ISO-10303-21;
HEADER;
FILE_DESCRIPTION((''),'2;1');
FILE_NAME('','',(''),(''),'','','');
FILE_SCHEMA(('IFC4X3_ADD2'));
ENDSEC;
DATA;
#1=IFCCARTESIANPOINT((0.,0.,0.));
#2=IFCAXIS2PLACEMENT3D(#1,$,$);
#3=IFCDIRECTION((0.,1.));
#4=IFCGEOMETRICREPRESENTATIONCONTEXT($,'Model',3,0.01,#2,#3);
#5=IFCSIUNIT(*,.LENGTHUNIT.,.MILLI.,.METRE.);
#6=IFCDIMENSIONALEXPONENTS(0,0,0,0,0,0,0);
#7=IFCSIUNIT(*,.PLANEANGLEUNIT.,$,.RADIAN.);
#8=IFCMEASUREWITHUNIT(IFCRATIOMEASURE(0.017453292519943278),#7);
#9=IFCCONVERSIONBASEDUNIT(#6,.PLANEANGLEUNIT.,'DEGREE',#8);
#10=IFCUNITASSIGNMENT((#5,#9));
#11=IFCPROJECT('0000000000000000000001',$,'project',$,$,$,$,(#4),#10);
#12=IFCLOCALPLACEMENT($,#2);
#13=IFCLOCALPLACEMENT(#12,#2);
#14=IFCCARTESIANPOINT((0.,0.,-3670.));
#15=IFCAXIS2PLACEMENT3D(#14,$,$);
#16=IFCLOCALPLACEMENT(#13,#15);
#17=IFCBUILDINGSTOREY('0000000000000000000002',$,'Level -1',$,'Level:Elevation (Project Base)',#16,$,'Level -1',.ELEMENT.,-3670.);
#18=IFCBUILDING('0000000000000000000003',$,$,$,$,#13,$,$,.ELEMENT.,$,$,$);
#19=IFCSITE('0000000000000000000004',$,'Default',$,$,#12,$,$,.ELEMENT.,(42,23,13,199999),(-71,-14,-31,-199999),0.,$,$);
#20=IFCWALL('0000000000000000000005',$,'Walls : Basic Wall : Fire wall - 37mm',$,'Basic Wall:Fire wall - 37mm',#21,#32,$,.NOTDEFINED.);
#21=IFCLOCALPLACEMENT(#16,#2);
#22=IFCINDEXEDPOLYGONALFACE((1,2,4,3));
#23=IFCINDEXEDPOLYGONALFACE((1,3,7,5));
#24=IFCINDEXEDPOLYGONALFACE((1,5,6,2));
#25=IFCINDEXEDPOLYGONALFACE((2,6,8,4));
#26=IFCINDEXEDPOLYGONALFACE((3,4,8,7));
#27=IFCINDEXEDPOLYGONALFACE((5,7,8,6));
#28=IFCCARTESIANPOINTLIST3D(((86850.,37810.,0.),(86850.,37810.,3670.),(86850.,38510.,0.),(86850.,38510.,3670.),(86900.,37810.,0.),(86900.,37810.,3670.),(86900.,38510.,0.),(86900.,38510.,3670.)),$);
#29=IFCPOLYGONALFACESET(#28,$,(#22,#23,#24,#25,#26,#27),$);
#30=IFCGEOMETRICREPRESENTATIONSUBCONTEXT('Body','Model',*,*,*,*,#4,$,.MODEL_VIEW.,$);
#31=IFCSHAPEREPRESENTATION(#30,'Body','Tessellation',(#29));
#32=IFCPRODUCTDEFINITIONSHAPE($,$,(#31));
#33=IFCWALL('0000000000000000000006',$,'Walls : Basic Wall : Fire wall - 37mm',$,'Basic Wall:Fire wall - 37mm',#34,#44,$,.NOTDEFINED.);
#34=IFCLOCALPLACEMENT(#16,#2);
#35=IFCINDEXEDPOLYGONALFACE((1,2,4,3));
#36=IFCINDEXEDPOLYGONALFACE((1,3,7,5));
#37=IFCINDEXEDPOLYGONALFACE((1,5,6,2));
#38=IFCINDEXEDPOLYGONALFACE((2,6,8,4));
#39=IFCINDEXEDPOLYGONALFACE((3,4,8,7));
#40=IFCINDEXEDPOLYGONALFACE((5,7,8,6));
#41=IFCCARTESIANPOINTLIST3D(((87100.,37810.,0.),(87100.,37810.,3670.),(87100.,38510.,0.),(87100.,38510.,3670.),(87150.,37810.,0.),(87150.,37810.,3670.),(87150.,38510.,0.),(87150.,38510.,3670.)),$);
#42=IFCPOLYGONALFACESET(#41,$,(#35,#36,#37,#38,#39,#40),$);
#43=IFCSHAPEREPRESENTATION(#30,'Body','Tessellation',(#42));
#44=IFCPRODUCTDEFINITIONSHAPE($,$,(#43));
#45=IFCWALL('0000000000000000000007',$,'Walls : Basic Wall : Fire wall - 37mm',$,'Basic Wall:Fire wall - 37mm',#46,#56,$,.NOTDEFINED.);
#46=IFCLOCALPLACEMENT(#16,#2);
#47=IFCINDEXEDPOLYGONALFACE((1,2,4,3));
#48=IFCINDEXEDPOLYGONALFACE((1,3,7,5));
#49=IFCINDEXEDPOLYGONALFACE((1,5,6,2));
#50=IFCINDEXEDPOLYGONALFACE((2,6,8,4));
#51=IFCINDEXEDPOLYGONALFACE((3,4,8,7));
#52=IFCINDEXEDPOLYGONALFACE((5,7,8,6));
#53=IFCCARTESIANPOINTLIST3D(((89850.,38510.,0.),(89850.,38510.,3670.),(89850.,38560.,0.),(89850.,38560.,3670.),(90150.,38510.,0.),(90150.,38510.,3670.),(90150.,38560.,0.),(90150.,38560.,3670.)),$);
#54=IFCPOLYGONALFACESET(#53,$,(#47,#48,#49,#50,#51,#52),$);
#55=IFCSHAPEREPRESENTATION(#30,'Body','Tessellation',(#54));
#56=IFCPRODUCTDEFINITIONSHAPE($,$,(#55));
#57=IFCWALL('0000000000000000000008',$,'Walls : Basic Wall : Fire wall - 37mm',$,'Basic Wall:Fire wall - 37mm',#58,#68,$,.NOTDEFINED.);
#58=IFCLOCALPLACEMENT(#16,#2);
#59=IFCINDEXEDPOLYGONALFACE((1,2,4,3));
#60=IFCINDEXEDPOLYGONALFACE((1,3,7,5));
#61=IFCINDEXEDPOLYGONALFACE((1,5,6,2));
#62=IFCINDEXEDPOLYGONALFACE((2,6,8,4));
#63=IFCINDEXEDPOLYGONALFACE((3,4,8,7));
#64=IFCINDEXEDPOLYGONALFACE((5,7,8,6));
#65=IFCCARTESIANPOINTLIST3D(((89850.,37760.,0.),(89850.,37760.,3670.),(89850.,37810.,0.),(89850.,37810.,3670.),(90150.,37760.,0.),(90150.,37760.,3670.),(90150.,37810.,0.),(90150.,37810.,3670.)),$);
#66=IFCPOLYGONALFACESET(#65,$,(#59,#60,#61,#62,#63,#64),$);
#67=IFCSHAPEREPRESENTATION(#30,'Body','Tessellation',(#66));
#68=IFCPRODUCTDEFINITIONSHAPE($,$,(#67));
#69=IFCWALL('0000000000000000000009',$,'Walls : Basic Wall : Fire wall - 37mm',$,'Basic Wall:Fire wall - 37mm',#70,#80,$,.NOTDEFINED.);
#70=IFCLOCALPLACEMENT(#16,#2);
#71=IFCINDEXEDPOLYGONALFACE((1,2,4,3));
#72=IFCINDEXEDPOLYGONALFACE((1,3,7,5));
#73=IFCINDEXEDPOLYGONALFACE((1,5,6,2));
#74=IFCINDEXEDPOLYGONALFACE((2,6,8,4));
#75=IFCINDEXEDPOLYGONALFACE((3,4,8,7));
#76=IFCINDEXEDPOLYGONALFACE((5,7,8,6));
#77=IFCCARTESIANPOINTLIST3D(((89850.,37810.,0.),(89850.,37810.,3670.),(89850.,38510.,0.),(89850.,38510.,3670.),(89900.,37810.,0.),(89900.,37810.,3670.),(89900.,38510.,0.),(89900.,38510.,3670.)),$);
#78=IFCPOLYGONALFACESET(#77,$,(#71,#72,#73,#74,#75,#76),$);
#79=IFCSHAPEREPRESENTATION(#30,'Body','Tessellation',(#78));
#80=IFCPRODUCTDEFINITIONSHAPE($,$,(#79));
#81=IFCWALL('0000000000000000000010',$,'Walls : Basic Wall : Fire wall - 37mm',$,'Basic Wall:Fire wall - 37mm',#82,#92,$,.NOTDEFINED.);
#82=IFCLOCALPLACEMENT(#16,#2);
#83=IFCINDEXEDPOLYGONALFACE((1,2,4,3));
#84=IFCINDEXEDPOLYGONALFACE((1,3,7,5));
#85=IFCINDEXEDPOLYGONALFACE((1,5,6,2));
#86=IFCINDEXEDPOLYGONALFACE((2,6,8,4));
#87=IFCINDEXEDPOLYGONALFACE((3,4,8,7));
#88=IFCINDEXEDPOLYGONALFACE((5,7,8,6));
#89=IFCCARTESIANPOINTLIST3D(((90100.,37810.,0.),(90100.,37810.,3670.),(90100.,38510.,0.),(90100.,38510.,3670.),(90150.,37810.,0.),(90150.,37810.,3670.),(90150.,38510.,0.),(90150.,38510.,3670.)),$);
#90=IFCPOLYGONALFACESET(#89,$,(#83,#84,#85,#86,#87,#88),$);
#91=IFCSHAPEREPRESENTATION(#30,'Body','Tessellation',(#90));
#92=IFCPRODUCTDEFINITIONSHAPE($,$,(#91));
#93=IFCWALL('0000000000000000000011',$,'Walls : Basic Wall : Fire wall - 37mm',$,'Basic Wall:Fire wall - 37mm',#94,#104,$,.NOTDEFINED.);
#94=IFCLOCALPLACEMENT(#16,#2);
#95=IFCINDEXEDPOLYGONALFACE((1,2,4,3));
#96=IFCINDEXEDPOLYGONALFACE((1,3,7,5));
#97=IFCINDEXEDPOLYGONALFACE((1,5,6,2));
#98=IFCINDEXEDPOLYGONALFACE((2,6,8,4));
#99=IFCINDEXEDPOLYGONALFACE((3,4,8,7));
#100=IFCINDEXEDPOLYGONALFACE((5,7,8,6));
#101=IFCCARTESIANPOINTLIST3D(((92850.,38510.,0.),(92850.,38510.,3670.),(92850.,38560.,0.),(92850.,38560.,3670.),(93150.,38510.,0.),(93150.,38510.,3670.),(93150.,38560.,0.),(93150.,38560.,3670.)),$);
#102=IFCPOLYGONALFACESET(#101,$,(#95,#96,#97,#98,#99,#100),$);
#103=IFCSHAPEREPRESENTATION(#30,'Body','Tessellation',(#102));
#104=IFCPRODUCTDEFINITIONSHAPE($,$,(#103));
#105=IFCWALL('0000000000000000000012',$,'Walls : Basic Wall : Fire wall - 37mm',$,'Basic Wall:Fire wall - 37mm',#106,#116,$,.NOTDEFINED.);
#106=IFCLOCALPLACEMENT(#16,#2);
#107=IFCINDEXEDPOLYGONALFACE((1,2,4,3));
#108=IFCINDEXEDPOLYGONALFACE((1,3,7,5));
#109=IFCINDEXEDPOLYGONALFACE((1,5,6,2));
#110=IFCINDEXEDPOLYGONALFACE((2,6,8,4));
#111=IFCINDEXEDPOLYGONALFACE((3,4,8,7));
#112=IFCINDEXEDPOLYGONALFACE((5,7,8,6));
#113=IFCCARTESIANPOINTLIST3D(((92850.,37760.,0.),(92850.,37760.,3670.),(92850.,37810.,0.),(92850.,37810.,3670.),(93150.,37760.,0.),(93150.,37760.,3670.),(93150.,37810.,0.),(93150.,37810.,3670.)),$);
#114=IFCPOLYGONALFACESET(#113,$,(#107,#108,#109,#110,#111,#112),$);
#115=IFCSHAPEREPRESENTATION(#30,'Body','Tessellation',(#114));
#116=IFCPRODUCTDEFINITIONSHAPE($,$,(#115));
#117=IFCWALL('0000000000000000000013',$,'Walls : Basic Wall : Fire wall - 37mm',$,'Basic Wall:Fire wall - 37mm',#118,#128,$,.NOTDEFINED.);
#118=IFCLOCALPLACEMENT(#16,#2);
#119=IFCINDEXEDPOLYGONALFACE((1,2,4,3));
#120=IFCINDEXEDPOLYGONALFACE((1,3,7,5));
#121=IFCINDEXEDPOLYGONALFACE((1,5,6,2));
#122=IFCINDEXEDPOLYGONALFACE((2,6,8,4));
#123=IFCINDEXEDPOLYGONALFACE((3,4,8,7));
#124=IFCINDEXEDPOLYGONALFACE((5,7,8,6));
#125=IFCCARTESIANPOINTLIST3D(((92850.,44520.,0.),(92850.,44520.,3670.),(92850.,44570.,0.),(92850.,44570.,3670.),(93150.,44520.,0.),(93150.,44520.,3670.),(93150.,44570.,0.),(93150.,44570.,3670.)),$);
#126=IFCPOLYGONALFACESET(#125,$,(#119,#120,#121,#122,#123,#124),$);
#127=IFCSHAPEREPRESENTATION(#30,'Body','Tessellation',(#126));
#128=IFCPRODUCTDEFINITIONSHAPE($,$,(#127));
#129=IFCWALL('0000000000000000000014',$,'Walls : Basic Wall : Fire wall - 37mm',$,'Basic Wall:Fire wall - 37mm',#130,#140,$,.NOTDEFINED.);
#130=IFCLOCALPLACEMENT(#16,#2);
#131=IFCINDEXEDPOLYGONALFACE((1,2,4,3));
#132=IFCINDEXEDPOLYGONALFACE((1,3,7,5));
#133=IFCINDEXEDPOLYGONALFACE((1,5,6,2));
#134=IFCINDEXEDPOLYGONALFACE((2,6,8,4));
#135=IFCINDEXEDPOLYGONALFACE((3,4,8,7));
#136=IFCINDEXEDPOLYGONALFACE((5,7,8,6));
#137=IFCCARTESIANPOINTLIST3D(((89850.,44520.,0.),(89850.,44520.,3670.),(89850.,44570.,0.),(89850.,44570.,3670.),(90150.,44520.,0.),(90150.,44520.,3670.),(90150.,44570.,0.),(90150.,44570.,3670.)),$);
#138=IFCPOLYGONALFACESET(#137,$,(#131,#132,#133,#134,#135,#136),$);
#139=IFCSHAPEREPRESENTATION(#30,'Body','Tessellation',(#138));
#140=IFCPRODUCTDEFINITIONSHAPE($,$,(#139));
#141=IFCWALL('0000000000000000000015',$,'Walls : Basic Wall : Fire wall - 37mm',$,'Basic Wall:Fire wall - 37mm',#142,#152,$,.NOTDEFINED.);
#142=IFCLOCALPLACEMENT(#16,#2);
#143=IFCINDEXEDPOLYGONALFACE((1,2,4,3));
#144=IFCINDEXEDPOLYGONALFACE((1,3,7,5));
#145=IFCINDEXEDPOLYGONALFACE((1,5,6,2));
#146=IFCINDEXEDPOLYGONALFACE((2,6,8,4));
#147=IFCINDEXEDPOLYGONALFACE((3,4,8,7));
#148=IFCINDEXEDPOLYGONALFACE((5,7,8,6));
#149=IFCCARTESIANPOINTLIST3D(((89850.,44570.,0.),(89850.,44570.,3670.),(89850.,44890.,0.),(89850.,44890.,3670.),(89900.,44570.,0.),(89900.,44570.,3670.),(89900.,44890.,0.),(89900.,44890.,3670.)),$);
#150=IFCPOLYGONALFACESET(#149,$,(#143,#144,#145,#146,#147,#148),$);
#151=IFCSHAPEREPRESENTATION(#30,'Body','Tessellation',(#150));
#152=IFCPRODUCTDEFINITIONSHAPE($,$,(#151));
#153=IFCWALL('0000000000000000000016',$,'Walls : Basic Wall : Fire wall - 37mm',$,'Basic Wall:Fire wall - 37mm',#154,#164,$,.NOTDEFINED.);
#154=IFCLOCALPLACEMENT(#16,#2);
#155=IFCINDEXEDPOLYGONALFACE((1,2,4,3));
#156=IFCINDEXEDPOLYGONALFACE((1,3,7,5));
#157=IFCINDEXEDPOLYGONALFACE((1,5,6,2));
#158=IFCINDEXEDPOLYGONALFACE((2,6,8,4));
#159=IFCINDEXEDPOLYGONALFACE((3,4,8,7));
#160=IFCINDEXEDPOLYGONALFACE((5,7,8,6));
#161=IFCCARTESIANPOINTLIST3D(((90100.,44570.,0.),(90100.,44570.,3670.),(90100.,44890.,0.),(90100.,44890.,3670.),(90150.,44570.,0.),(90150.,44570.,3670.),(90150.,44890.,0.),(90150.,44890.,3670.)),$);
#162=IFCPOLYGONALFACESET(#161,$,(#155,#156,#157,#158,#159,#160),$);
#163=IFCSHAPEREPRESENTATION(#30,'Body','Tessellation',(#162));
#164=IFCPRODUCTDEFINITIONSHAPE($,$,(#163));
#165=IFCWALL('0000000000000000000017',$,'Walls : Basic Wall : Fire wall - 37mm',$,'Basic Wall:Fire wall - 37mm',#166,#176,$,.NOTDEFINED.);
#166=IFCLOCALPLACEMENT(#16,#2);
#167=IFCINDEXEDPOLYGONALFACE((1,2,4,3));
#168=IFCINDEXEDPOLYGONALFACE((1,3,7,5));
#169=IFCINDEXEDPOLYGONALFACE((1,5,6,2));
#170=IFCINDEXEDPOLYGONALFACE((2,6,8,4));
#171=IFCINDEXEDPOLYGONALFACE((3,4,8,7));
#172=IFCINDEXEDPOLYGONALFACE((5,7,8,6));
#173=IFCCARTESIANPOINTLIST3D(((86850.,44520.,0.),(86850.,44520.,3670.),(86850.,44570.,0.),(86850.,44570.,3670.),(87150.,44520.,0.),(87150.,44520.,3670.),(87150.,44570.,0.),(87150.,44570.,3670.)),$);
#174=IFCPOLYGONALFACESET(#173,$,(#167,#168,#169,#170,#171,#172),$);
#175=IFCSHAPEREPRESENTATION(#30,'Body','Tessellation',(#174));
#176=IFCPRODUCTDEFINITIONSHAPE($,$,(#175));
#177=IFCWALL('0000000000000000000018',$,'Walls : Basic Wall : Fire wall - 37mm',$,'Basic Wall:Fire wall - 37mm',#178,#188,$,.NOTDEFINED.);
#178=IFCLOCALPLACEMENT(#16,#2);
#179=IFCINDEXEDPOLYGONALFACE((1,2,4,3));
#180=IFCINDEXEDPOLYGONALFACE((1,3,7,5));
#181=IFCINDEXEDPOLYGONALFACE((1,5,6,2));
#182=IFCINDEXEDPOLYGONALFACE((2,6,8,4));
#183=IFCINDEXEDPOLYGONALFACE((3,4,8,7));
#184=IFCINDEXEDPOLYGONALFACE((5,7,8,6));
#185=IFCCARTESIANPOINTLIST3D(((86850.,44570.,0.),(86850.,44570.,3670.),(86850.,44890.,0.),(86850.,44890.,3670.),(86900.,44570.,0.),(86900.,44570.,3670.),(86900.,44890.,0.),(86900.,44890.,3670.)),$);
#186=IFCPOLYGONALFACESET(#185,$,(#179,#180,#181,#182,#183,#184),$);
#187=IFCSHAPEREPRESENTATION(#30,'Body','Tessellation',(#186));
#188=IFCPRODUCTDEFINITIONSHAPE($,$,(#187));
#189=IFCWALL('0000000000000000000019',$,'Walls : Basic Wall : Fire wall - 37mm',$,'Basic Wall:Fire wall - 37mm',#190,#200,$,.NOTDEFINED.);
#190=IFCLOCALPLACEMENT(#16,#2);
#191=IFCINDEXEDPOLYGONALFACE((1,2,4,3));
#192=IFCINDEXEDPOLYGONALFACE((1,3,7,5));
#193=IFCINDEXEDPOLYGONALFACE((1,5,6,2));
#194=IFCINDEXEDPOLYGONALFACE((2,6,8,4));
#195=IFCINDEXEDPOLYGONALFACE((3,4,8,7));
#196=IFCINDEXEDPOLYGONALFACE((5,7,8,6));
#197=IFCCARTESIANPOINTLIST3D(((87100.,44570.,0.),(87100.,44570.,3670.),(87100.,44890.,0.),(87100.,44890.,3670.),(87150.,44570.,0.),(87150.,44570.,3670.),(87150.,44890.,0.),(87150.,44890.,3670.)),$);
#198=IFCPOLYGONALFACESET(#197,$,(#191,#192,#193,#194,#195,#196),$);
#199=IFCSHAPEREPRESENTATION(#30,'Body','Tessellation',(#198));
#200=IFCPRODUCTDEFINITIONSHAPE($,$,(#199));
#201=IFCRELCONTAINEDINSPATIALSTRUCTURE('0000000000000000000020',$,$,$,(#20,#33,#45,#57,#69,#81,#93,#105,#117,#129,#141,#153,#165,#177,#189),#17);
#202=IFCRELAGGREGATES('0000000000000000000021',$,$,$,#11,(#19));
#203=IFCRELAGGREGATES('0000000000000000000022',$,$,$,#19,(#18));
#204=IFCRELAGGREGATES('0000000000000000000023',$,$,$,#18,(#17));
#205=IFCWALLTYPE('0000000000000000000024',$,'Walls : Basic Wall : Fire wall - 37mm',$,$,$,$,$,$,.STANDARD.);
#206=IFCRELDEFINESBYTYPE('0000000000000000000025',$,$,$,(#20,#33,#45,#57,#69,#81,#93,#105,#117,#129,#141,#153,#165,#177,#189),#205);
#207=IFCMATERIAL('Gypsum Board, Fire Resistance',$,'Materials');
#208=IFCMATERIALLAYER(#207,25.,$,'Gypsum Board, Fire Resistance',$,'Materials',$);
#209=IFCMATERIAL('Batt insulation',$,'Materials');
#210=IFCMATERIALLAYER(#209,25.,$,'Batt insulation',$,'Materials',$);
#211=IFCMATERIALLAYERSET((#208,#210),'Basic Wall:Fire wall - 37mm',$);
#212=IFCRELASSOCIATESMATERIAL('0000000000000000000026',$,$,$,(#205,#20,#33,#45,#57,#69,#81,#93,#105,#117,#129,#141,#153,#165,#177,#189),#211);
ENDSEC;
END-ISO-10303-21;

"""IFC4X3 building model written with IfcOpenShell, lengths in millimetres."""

from ifc_helpers import new_model, entity, si_unit, converted_unit, direction, frame, frame_2d, origin, place, context, subcontext, project, spatial, rectangle, extrude, material, layer, layer_set, type_object, element, save


model = new_model("IFC4X3")

# Units and contexts
model_context = context("Model", 3, precision=0.01, world=origin(), true_north=direction((0.0, 1.0)))
body_context = subcontext(model_context, "Body", "Model", "MODEL_VIEW")
ifc_project = project(units=[si_unit("LENGTHUNIT", "METRE", prefix="MILLI"), converted_unit("PLANEANGLEUNIT", "DEGREE", entity("IfcRatioMeasure", 0.017453292519943278), si_unit("PLANEANGLEUNIT", "RADIAN"), dimensions=[0, 0, 0, 0, 0, 0, 0])], contexts=[model_context])

# Site, building, storey
site_placement = place(None, origin())
site = spatial("IfcSite", under=ifc_project, at=site_placement, Name="Default", CompositionType="ELEMENT", RefLatitude=(42, 23, 13, 199999), RefLongitude=(-71, -14, -31, -199999), RefElevation=0.0)
building_placement = place(site_placement, origin())
building = spatial("IfcBuilding", under=site, at=building_placement, CompositionType="ELEMENT")
storey_placement = place(building_placement, frame((0.0, 0.0, -3670.0)))
storey = spatial("IfcBuildingStorey", under=building, at=storey_placement, Name="Level -1", ObjectType="Level:Elevation (Project Base)", LongName="Level -1", CompositionType="ELEMENT", Elevation=-3670.0)

# Walls
ifc_material_1 = material(Name="Gypsum Board, Fire Resistance", Category="Materials")
ifc_layer_1 = layer(ifc_material_1, 25.0, Name="Gypsum Board, Fire Resistance", Category="Materials")
ifc_material_2 = material(Name="Batt insulation", Category="Materials")
ifc_layer_2 = layer(ifc_material_2, 25.0, Name="Batt insulation", Category="Materials")
ifc_layer_set = layer_set([ifc_layer_1, ifc_layer_2], Name="Basic Wall:Fire wall - 37mm")
wall_type = type_object("IfcWallType", Name="Walls : Basic Wall : Fire wall - 37mm", PredefinedType="STANDARD", material=ifc_layer_set)
for number, where, z_axis, x_axis, name in (
    (1, (86875.0, 38510.0, 0.0), (0.0, 0.0, 1.0), (0.0, -1.0, 0.0), "Walls : Basic Wall : Fire wall - 37mm"),
    (2, (87125.0, 38510.0, 0.0), (0.0, 0.0, 1.0), (0.0, -1.0, 0.0), "Walls : Basic Wall : Fire wall - 37mm"),
):
    element("IfcWall", number, at=place(storey_placement, frame(where, z_axis=z_axis, x_axis=x_axis)), inside=storey, type_object=wall_type, material=ifc_layer_set, Name=name, ObjectType="Basic Wall:Fire wall - 37mm", PredefinedType="NOTDEFINED", context=body_context, shape_type="SweptSolid", body=[
        extrude(rectangle(XDim=700.0, YDim=50.0, at=frame_2d((350.0, 0.0), x_axis=(-1.0, 0.0))), origin(), (0.0, 0.0, 1.0), 3670.0),
    ])
wall_1_placement = place(storey_placement, frame((89850.0, 38535.0, 0.0)))
element("IfcWall", 3, at=wall_1_placement, inside=storey, type_object=wall_type, material=ifc_layer_set, Name="Walls : Basic Wall : Fire wall - 37mm", ObjectType="Basic Wall:Fire wall - 37mm", PredefinedType="NOTDEFINED", context=body_context, shape_type="SweptSolid", body=[
    extrude(rectangle(XDim=300.0, YDim=50.0, at=frame_2d((150.0, 0.0), x_axis=(-1.0, 0.0))), origin(), (0.0, 0.0, 1.0), 3670.0),
])
wall_2_placement = place(storey_placement, frame((89850.0, 37785.0, 0.0)))
element("IfcWall", 4, at=wall_2_placement, inside=storey, type_object=wall_type, material=ifc_layer_set, Name="Walls : Basic Wall : Fire wall - 37mm", ObjectType="Basic Wall:Fire wall - 37mm", PredefinedType="NOTDEFINED", context=body_context, shape_type="SweptSolid", body=[
    extrude(rectangle(XDim=300.0, YDim=50.0, at=frame_2d((150.0, 0.0), x_axis=(-1.0, 0.0))), origin(), (0.0, 0.0, 1.0), 3670.0),
])
for number, where, z_axis, x_axis, name in (
    (5, (89875.0, 38510.0, 0.0), (0.0, 0.0, 1.0), (0.0, -1.0, 0.0), "Walls : Basic Wall : Fire wall - 37mm"),
    (6, (90125.0, 38510.0, 0.0), (0.0, 0.0, 1.0), (0.0, -1.0, 0.0), "Walls : Basic Wall : Fire wall - 37mm"),
):
    element("IfcWall", number, at=place(storey_placement, frame(where, z_axis=z_axis, x_axis=x_axis)), inside=storey, type_object=wall_type, material=ifc_layer_set, Name=name, ObjectType="Basic Wall:Fire wall - 37mm", PredefinedType="NOTDEFINED", context=body_context, shape_type="SweptSolid", body=[
        extrude(rectangle(XDim=700.0, YDim=50.0, at=frame_2d((350.0, 0.0), x_axis=(-1.0, 0.0))), origin(), (0.0, 0.0, 1.0), 3670.0),
    ])
wall_3_placement = place(storey_placement, frame((92850.0, 38535.0, 0.0)))
element("IfcWall", 7, at=wall_3_placement, inside=storey, type_object=wall_type, material=ifc_layer_set, Name="Walls : Basic Wall : Fire wall - 37mm", ObjectType="Basic Wall:Fire wall - 37mm", PredefinedType="NOTDEFINED", context=body_context, shape_type="SweptSolid", body=[
    extrude(rectangle(XDim=300.0, YDim=50.0, at=frame_2d((150.0, 0.0), x_axis=(-1.0, 0.0))), origin(), (0.0, 0.0, 1.0), 3670.0),
])
wall_4_placement = place(storey_placement, frame((92850.0, 37785.0, 0.0)))
element("IfcWall", 8, at=wall_4_placement, inside=storey, type_object=wall_type, material=ifc_layer_set, Name="Walls : Basic Wall : Fire wall - 37mm", ObjectType="Basic Wall:Fire wall - 37mm", PredefinedType="NOTDEFINED", context=body_context, shape_type="SweptSolid", body=[
    extrude(rectangle(XDim=300.0, YDim=50.0, at=frame_2d((150.0, 0.0), x_axis=(-1.0, 0.0))), origin(), (0.0, 0.0, 1.0), 3670.0),
])
for number, where, name in (
    (9, (92850.0, 44545.0, 0.0), "Walls : Basic Wall : Fire wall - 37mm"),
    (10, (89850.0, 44545.0, 0.0), "Walls : Basic Wall : Fire wall - 37mm"),
):
    element("IfcWall", number, at=place(storey_placement, frame(where)), inside=storey, type_object=wall_type, material=ifc_layer_set, Name=name, ObjectType="Basic Wall:Fire wall - 37mm", PredefinedType="NOTDEFINED", context=body_context, shape_type="SweptSolid", body=[
        extrude(rectangle(XDim=300.0, YDim=50.0, at=frame_2d((150.0, 0.0), x_axis=(-1.0, 0.0))), origin(), (0.0, 0.0, 1.0), 3670.0),
    ])
for number, where, z_axis, x_axis, name in (
    (11, (89875.0, 44890.0, 0.0), (0.0, 0.0, 1.0), (0.0, -1.0, 0.0), "Walls : Basic Wall : Fire wall - 37mm"),
    (12, (90125.0, 44890.0, 0.0), (0.0, 0.0, 1.0), (0.0, -1.0, 0.0), "Walls : Basic Wall : Fire wall - 37mm"),
):
    element("IfcWall", number, at=place(storey_placement, frame(where, z_axis=z_axis, x_axis=x_axis)), inside=storey, type_object=wall_type, material=ifc_layer_set, Name=name, ObjectType="Basic Wall:Fire wall - 37mm", PredefinedType="NOTDEFINED", context=body_context, shape_type="SweptSolid", body=[
        extrude(rectangle(XDim=320.0, YDim=50.0, at=frame_2d((160.0, 0.0), x_axis=(-1.0, 0.0))), origin(), (0.0, 0.0, 1.0), 3670.0),
    ])
wall_5_placement = place(storey_placement, frame((86850.0, 44545.0, 0.0)))
element("IfcWall", 13, at=wall_5_placement, inside=storey, type_object=wall_type, material=ifc_layer_set, Name="Walls : Basic Wall : Fire wall - 37mm", ObjectType="Basic Wall:Fire wall - 37mm", PredefinedType="NOTDEFINED", context=body_context, shape_type="SweptSolid", body=[
    extrude(rectangle(XDim=300.0, YDim=50.0, at=frame_2d((150.0, 0.0), x_axis=(-1.0, 0.0))), origin(), (0.0, 0.0, 1.0), 3670.0),
])
wall_6_placement = place(storey_placement, frame((86875.0, 44890.0, 0.0), z_axis=(0.0, 0.0, 1.0), x_axis=(0.0, -1.0, 0.0)))
element("IfcWall", 14, at=wall_6_placement, inside=storey, type_object=wall_type, material=ifc_layer_set, Name="Walls : Basic Wall : Fire wall - 37mm", ObjectType="Basic Wall:Fire wall - 37mm", PredefinedType="NOTDEFINED", context=body_context, shape_type="SweptSolid", body=[
    extrude(rectangle(XDim=320.0, YDim=50.0, at=frame_2d((160.0, 0.0), x_axis=(-1.0, 0.0))), origin(), (0.0, 0.0, 1.0), 3670.0),
])
wall_7_placement = place(storey_placement, frame((87125.0, 44890.0, 0.0), z_axis=(0.0, 0.0, 1.0), x_axis=(0.0, -1.0, 0.0)))
element("IfcWall", 15, at=wall_7_placement, inside=storey, type_object=wall_type, material=ifc_layer_set, Name="Walls : Basic Wall : Fire wall - 37mm", ObjectType="Basic Wall:Fire wall - 37mm", PredefinedType="NOTDEFINED", context=body_context, shape_type="SweptSolid", body=[
    extrude(rectangle(XDim=320.0, YDim=50.0, at=frame_2d((160.0, 0.0), x_axis=(-1.0, 0.0))), origin(), (0.0, 0.0, 1.0), 3670.0),
])

save(model, "model.ifc")
